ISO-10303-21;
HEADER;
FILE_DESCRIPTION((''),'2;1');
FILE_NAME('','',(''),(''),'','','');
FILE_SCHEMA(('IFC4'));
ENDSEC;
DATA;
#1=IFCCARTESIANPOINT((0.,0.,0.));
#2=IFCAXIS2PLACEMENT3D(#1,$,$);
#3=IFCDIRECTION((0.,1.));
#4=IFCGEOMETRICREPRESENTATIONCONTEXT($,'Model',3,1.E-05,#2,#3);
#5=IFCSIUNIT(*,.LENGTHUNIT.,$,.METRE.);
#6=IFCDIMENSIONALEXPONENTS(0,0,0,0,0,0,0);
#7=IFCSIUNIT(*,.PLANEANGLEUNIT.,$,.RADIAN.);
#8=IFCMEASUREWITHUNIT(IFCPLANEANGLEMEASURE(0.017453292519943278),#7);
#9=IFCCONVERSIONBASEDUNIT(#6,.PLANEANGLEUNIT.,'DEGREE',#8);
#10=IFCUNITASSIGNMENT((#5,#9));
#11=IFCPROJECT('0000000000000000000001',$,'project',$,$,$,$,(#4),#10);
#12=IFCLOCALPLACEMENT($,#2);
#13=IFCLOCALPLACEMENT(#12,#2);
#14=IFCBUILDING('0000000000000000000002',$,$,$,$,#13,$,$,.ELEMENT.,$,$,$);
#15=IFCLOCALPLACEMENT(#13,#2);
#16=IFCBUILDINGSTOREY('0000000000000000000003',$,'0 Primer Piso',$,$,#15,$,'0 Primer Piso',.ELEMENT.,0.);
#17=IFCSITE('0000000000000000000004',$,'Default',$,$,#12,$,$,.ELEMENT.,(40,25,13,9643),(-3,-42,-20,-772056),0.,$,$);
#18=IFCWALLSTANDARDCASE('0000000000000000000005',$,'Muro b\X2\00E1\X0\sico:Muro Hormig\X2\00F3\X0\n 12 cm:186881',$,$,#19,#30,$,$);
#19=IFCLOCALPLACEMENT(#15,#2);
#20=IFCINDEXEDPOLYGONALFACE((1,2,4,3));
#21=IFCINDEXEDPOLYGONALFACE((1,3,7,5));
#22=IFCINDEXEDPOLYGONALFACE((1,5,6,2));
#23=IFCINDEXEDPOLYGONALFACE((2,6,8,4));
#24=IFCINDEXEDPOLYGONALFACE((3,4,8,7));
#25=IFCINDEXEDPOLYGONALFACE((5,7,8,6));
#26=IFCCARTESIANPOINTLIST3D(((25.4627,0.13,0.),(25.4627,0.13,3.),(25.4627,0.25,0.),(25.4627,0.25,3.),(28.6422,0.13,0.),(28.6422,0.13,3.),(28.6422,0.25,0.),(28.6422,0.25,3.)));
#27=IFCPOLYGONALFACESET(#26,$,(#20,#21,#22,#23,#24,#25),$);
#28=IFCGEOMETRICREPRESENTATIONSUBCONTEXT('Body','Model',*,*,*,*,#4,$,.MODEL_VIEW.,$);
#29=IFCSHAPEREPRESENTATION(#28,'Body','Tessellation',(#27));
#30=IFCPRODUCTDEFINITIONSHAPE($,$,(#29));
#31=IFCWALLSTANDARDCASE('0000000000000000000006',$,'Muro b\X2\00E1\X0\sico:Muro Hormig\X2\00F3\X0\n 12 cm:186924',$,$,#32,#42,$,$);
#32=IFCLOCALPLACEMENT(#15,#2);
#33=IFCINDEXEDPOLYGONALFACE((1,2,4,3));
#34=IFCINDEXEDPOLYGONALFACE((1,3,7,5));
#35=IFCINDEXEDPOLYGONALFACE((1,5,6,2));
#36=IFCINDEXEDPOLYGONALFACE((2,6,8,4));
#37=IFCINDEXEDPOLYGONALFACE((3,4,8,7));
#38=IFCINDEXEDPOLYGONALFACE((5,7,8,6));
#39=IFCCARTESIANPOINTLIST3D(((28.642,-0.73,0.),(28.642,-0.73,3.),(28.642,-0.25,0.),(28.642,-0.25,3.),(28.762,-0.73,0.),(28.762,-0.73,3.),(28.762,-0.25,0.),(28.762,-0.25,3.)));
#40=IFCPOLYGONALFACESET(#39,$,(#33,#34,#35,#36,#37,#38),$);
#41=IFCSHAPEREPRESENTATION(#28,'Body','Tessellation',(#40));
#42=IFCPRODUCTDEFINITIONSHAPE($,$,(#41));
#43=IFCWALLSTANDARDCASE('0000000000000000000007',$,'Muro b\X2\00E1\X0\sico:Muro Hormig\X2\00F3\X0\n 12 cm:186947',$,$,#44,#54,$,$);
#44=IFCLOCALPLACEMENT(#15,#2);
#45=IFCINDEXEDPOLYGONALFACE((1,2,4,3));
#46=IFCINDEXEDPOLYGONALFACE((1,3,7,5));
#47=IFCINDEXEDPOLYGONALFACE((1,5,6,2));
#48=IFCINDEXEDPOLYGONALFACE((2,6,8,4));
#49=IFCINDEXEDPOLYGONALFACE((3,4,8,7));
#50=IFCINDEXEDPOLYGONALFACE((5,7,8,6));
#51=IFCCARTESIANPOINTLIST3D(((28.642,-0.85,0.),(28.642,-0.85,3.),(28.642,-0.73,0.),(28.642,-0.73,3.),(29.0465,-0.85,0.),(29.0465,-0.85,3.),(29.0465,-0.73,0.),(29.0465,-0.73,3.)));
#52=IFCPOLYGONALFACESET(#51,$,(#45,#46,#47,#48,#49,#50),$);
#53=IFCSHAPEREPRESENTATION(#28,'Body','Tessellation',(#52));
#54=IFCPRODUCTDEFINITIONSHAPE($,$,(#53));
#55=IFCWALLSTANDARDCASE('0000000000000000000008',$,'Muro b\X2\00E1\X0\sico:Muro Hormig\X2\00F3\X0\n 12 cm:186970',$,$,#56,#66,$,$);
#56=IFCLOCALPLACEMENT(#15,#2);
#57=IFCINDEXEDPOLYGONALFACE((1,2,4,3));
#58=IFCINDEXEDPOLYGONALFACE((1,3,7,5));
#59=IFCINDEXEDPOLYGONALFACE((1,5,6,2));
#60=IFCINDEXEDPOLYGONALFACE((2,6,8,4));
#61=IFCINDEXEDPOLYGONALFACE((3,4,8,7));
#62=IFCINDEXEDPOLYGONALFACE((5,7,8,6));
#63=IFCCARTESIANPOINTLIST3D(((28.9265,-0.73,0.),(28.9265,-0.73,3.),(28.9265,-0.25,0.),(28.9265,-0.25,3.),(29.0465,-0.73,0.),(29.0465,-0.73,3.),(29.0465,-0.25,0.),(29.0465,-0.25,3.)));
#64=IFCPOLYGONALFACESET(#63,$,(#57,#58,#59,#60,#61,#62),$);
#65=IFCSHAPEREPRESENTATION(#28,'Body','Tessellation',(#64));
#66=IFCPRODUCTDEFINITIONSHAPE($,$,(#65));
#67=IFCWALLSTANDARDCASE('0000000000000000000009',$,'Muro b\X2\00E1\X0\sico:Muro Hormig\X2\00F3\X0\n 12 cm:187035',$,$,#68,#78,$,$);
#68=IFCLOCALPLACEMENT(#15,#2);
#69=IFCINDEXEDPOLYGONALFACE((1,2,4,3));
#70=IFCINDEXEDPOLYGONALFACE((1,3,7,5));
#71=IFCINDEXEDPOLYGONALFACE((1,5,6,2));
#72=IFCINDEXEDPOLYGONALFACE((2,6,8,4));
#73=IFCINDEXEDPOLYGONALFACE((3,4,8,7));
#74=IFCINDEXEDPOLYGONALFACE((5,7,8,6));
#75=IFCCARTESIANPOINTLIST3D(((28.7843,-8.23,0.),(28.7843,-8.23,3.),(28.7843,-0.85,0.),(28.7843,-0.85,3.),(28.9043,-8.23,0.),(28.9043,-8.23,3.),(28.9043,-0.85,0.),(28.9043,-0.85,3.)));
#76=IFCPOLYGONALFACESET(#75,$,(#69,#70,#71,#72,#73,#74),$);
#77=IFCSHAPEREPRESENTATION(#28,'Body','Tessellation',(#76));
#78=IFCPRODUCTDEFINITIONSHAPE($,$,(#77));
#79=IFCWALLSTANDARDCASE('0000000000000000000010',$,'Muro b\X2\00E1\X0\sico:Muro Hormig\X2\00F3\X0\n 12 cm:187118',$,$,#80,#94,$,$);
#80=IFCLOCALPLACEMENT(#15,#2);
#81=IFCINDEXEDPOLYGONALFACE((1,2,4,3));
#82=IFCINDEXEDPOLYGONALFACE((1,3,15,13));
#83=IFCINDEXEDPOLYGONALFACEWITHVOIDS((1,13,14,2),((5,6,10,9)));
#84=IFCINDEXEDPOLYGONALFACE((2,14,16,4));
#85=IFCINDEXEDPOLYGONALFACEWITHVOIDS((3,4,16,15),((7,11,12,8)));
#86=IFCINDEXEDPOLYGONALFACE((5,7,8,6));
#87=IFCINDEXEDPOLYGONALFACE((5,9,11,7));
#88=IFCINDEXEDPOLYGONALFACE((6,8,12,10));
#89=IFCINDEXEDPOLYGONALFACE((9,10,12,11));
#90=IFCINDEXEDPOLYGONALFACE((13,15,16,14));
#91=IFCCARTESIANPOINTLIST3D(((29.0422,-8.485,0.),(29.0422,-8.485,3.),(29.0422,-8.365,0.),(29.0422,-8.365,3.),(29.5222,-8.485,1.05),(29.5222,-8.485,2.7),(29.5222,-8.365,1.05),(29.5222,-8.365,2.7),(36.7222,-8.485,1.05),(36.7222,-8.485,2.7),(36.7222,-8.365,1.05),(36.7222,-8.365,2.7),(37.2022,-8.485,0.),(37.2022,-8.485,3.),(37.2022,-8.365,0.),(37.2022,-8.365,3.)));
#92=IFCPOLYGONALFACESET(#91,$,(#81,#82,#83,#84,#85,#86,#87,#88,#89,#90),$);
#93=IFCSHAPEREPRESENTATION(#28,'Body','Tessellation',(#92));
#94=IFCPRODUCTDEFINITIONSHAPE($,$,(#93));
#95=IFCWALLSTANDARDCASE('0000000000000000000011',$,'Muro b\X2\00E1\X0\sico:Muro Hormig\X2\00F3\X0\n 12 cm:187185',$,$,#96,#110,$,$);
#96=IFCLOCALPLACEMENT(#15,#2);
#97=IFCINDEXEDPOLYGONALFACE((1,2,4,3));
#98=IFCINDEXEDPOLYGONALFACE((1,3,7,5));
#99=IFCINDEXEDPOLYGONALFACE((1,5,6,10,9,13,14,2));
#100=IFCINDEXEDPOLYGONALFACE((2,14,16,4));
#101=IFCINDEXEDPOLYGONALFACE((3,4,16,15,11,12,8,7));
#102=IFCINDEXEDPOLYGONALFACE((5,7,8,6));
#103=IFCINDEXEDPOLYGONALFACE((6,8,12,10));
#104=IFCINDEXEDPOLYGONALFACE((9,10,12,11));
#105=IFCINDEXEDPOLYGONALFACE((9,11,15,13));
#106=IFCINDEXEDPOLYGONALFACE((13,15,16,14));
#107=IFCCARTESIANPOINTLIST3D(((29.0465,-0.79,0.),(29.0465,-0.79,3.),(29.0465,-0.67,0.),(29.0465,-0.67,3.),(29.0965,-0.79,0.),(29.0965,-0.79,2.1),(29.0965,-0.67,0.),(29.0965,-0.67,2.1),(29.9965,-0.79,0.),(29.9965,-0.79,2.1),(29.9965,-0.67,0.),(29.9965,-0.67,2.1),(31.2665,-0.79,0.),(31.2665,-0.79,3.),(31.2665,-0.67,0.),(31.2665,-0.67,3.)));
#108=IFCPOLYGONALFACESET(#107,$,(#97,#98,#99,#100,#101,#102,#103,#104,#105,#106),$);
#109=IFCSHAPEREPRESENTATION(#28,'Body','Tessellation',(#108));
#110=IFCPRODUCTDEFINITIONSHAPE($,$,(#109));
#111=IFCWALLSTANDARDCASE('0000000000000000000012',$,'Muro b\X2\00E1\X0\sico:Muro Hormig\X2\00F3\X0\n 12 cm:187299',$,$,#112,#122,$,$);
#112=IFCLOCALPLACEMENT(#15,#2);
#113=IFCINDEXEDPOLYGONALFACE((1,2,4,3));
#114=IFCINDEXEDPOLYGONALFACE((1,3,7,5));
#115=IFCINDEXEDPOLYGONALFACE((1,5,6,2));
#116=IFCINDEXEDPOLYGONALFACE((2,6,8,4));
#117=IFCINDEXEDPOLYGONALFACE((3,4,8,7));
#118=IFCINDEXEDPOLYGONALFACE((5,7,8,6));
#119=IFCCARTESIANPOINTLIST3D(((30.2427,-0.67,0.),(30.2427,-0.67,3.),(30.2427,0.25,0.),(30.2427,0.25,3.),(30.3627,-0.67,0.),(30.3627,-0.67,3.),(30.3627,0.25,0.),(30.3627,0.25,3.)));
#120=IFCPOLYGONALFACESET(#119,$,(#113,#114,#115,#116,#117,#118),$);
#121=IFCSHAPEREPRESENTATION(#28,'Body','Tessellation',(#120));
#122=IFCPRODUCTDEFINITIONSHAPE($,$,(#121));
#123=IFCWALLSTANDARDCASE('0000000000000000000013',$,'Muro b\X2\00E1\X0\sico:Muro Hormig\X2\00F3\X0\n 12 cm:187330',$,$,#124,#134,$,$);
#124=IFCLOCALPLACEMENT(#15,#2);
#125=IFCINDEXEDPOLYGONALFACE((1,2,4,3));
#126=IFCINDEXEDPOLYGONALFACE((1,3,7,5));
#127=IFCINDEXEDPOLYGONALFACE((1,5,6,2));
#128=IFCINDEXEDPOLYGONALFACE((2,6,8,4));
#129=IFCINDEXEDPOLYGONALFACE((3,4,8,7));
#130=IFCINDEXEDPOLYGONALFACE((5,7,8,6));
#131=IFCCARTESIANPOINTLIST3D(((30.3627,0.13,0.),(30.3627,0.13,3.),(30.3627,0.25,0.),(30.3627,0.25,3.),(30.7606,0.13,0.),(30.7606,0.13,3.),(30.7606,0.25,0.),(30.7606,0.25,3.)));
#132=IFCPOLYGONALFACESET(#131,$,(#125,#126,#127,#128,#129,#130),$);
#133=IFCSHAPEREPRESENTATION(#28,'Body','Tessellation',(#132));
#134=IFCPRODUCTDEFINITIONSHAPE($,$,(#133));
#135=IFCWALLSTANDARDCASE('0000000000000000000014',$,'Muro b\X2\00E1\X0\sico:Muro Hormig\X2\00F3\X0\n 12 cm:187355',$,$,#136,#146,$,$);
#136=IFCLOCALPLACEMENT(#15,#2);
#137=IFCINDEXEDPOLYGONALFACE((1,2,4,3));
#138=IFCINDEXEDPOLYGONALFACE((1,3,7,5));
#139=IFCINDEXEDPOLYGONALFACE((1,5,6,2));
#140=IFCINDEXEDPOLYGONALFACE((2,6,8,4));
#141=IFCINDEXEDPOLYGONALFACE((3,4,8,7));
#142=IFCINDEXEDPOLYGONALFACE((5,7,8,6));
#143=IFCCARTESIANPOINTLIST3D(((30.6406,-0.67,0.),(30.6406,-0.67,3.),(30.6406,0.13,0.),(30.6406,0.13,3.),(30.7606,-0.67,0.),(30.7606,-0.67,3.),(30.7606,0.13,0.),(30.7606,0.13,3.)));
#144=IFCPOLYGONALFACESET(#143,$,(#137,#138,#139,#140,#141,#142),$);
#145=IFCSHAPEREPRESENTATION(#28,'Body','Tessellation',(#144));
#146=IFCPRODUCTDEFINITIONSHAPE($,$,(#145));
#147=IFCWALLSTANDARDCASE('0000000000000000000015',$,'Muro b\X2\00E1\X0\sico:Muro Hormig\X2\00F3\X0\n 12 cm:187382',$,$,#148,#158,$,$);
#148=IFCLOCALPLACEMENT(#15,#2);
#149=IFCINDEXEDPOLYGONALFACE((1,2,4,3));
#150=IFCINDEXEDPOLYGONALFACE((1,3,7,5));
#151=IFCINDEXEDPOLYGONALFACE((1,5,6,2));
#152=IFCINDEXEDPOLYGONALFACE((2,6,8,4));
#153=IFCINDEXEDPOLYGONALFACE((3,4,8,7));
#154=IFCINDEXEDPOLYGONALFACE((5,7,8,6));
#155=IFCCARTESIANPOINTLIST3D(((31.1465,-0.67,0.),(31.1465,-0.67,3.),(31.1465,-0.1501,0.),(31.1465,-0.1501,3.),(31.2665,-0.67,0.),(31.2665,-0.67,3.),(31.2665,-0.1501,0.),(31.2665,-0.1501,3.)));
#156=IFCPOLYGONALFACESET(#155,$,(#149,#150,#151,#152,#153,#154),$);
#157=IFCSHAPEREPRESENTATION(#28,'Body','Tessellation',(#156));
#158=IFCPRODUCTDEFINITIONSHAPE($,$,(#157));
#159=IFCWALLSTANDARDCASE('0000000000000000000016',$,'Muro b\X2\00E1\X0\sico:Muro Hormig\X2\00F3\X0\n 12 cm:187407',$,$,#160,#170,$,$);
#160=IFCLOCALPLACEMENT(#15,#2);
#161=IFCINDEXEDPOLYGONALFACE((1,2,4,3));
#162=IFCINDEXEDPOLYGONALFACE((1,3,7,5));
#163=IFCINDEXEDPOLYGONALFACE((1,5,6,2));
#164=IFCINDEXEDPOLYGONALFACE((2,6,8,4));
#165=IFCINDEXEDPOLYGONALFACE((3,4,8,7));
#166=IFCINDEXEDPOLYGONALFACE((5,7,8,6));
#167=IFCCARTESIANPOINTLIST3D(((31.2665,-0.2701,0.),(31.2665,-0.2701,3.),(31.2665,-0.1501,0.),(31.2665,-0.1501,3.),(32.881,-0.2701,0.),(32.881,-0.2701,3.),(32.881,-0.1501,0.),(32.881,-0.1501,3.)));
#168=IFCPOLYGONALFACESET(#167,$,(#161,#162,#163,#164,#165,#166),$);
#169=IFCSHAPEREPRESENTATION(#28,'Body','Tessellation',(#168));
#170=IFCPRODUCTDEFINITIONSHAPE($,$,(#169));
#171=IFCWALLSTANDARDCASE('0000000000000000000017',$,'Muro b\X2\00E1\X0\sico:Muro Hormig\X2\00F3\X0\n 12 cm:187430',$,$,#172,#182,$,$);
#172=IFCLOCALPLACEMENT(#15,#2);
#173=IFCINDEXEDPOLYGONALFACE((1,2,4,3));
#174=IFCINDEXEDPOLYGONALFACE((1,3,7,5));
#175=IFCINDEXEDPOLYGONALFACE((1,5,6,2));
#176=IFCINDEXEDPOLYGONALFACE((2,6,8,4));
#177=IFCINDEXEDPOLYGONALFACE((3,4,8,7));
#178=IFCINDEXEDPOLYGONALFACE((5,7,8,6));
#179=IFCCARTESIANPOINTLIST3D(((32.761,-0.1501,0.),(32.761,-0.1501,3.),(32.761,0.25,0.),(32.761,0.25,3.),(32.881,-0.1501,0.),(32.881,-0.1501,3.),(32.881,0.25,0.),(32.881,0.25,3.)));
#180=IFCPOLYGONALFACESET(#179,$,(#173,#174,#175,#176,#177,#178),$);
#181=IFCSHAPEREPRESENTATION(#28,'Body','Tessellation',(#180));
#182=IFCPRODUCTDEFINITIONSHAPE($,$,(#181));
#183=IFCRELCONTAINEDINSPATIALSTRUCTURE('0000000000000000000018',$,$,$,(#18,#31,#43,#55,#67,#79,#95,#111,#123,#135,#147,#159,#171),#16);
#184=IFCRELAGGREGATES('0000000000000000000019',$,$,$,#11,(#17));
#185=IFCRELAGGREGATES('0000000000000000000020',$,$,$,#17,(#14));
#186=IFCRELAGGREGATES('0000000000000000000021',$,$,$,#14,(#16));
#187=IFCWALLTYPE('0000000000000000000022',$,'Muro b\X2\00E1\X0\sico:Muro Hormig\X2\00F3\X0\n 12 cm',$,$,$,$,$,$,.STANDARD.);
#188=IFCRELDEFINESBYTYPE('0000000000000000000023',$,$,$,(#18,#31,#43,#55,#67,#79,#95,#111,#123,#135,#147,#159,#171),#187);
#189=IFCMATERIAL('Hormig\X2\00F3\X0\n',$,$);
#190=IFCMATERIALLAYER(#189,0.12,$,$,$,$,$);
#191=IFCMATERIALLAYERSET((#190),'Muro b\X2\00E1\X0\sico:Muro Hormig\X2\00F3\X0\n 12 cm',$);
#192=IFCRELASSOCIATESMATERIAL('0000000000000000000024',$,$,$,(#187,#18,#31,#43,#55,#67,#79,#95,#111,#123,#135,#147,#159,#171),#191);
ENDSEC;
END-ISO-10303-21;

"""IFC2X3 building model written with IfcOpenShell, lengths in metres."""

from ifc_helpers import new_model, entity, si_unit, converted_unit, direction, frame, frame_2d, origin, place, context, subcontext, project, spatial, rectangle, extrude, material, layer, layer_set, layer_usage, type_object, element, save


model = new_model("IFC2X3")

# Units and contexts
model_context = context("Model", 3, precision=1e-05, world=origin(), true_north=direction((0.0, 1.0)))
body_context = subcontext(model_context, "Body", "Model", "MODEL_VIEW")
ifc_project = project(units=[si_unit("LENGTHUNIT", "METRE"), converted_unit("PLANEANGLEUNIT", "DEGREE", entity("IfcPlaneAngleMeasure", 0.017453292519943278), si_unit("PLANEANGLEUNIT", "RADIAN"), dimensions=[0, 0, 0, 0, 0, 0, 0])], contexts=[model_context])

# Site, building, storey
site_placement = place(None, origin())
site = spatial("IfcSite", under=ifc_project, at=site_placement, Name="Default", CompositionType="ELEMENT", RefLatitude=(40, 25, 13, 9643), RefLongitude=(-3, -42, -20, -772056), RefElevation=0.0)
building_placement = place(site_placement, origin())
building = spatial("IfcBuilding", under=site, at=building_placement, CompositionType="ELEMENT")
storey_placement = place(building_placement, origin())
storey = spatial("IfcBuildingStorey", under=building, at=storey_placement, Name="0 Primer Piso", LongName="0 Primer Piso", CompositionType="ELEMENT", Elevation=0.0)

# Walls
ifc_material = material(Name="Hormigón")
ifc_layer = layer(ifc_material, 0.12)
ifc_layer_set = layer_set([ifc_layer], Name="Muro básico:Muro Hormigón 12 cm")
ifc_layer_usage_1 = layer_usage(ifc_layer_set, "AXIS2", "NEGATIVE", 0.06)
wall_type = type_object("IfcWallType", Name="Muro básico:Muro Hormigón 12 cm", PredefinedType="STANDARD", material=ifc_layer_set)
wall_1_placement = place(storey_placement, frame((25.4627, 0.19, 0.0)))
element("IfcWallStandardCase", 1, at=wall_1_placement, inside=storey, type_object=wall_type, material=ifc_layer_usage_1, Name="Muro básico:Muro Hormigón 12 cm:186881", context=body_context, shape_type="SweptSolid", body=[
    extrude(rectangle(XDim=3.1795, YDim=0.12, at=frame_2d((1.5897, 0.0), x_axis=(-1.0, 0.0))), origin(), (0.0, 0.0, 1.0), 3.0),
])
ifc_layer_usage_2 = layer_usage(ifc_layer_set, "AXIS2", "NEGATIVE", 0.06)
wall_2_placement = place(storey_placement, frame((28.702, -0.25, 0.0), z_axis=(0.0, 0.0, 1.0), x_axis=(0.0, -1.0, 0.0)))
element("IfcWallStandardCase", 2, at=wall_2_placement, inside=storey, type_object=wall_type, material=ifc_layer_usage_2, Name="Muro básico:Muro Hormigón 12 cm:186924", context=body_context, shape_type="SweptSolid", body=[
    extrude(rectangle(XDim=0.48, YDim=0.12, at=frame_2d((0.24, 0.0), x_axis=(-1.0, 0.0))), origin(), (0.0, 0.0, 1.0), 3.0),
])
ifc_layer_usage_3 = layer_usage(ifc_layer_set, "AXIS2", "NEGATIVE", 0.06)
wall_3_placement = place(storey_placement, frame((28.642, -0.79, 0.0)))
element("IfcWallStandardCase", 3, at=wall_3_placement, inside=storey, type_object=wall_type, material=ifc_layer_usage_3, Name="Muro básico:Muro Hormigón 12 cm:186947", context=body_context, shape_type="SweptSolid", body=[
    extrude(rectangle(XDim=0.4045, YDim=0.12, at=frame_2d((0.2023, 0.0), x_axis=(-1.0, 0.0))), origin(), (0.0, 0.0, 1.0), 3.0),
])
ifc_layer_usage_4 = layer_usage(ifc_layer_set, "AXIS2", "NEGATIVE", 0.06)
wall_4_placement = place(storey_placement, frame((28.9865, -0.73, 0.0), z_axis=(0.0, 0.0, 1.0), x_axis=(0.0, 1.0, 0.0)))
element("IfcWallStandardCase", 4, at=wall_4_placement, inside=storey, type_object=wall_type, material=ifc_layer_usage_4, Name="Muro básico:Muro Hormigón 12 cm:186970", context=body_context, shape_type="SweptSolid", body=[
    extrude(rectangle(XDim=0.48, YDim=0.12, at=frame_2d((0.24, 0.0), x_axis=(-1.0, 0.0))), origin(), (0.0, 0.0, 1.0), 3.0),
])
ifc_layer_usage_5 = layer_usage(ifc_layer_set, "AXIS2", "NEGATIVE", 0.06)
wall_5_placement = place(storey_placement, frame((28.8443, -0.85, 0.0), z_axis=(0.0, 0.0, 1.0), x_axis=(0.0, -1.0, 0.0)))
element("IfcWallStandardCase", 5, at=wall_5_placement, inside=storey, type_object=wall_type, material=ifc_layer_usage_5, Name="Muro básico:Muro Hormigón 12 cm:187035", context=body_context, shape_type="SweptSolid", body=[
    extrude(rectangle(XDim=7.38, YDim=0.12, at=frame_2d((3.69, 0.0), x_axis=(-1.0, 0.0))), origin(), (0.0, 0.0, 1.0), 3.0),
])

# Walls, openings
ifc_layer_usage_6 = layer_usage(ifc_layer_set, "AXIS2", "NEGATIVE", 0.06)
wall_6_placement = place(storey_placement, frame((29.0422, -8.425, 0.0)))
wall_6 = element("IfcWallStandardCase", 6, at=wall_6_placement, inside=storey, type_object=wall_type, material=ifc_layer_usage_6, Name="Muro básico:Muro Hormigón 12 cm:187118", context=body_context, shape_type="SweptSolid", body=[
    extrude(rectangle(XDim=8.16, YDim=0.12, at=frame_2d((4.08, 0.0), x_axis=(-1.0, 0.0))), origin(), (0.0, 0.0, 1.0), 3.0),
])
opening_1_placement = place(wall_6_placement, frame((0.48, -0.06, 1.05)))
element("IfcOpeningElement", 7, at=opening_1_placement, cuts=wall_6, ObjectType="Opening", context=body_context, shape_type="SweptSolid", body=[
    extrude(rectangle(XDim=1.65, YDim=7.2, at=frame_2d((0.825, 3.6), x_axis=(1.0, 0.0))), frame((0.0, 0.0, 0.0), z_axis=(0.0, 1.0, 0.0), x_axis=(0.0, 0.0, 1.0)), (0.0, 0.0, 1.0), 0.12),
])
ifc_layer_usage_7 = layer_usage(ifc_layer_set, "AXIS2", "NEGATIVE", 0.06)
wall_7_placement = place(storey_placement, frame((29.0465, -0.73, 0.0)))
wall_7 = element("IfcWallStandardCase", 8, at=wall_7_placement, inside=storey, type_object=wall_type, material=ifc_layer_usage_7, Name="Muro básico:Muro Hormigón 12 cm:187185", context=body_context, shape_type="SweptSolid", body=[
    extrude(rectangle(XDim=2.22, YDim=0.12, at=frame_2d((1.11, 0.0), x_axis=(-1.0, 0.0))), origin(), (0.0, 0.0, 1.0), 3.0),
])
opening_2_placement = place(wall_7_placement, frame((0.05, -0.06, 0.0)))
element("IfcOpeningElement", 9, at=opening_2_placement, cuts=wall_7, ObjectType="Opening", context=body_context, shape_type="SweptSolid", body=[
    extrude(rectangle(XDim=2.1, YDim=0.9, at=frame_2d((1.05, 0.45), x_axis=(1.0, 0.0))), frame((0.0, 0.0, 0.0), z_axis=(0.0, 1.0, 0.0), x_axis=(0.0, 0.0, 1.0)), (0.0, 0.0, 1.0), 0.12),
])

# Walls
ifc_layer_usage_8 = layer_usage(ifc_layer_set, "AXIS2", "NEGATIVE", 0.06)
wall_8_placement = place(storey_placement, frame((30.3027, -0.67, 0.0), z_axis=(0.0, 0.0, 1.0), x_axis=(0.0, 1.0, 0.0)))
element("IfcWallStandardCase", 10, at=wall_8_placement, inside=storey, type_object=wall_type, material=ifc_layer_usage_8, Name="Muro básico:Muro Hormigón 12 cm:187299", context=body_context, shape_type="SweptSolid", body=[
    extrude(rectangle(XDim=0.92, YDim=0.12, at=frame_2d((0.46, 0.0), x_axis=(-1.0, 0.0))), origin(), (0.0, 0.0, 1.0), 3.0),
])
ifc_layer_usage_9 = layer_usage(ifc_layer_set, "AXIS2", "NEGATIVE", 0.06)
wall_9_placement = place(storey_placement, frame((30.3627, 0.19, 0.0)))
element("IfcWallStandardCase", 11, at=wall_9_placement, inside=storey, type_object=wall_type, material=ifc_layer_usage_9, Name="Muro básico:Muro Hormigón 12 cm:187330", context=body_context, shape_type="SweptSolid", body=[
    extrude(rectangle(XDim=0.3979, YDim=0.12, at=frame_2d((0.199, 0.0), x_axis=(-1.0, 0.0))), origin(), (0.0, 0.0, 1.0), 3.0),
])
ifc_layer_usage_10 = layer_usage(ifc_layer_set, "AXIS2", "NEGATIVE", 0.06)
wall_10_placement = place(storey_placement, frame((30.7006, 0.13, 0.0), z_axis=(0.0, 0.0, 1.0), x_axis=(0.0, -1.0, 0.0)))
element("IfcWallStandardCase", 12, at=wall_10_placement, inside=storey, type_object=wall_type, material=ifc_layer_usage_10, Name="Muro básico:Muro Hormigón 12 cm:187355", context=body_context, shape_type="SweptSolid", body=[
    extrude(rectangle(XDim=0.8, YDim=0.12, at=frame_2d((0.4, 0.0), x_axis=(-1.0, 0.0))), origin(), (0.0, 0.0, 1.0), 3.0),
])
ifc_layer_usage_11 = layer_usage(ifc_layer_set, "AXIS2", "NEGATIVE", 0.06)
wall_11_placement = place(storey_placement, frame((31.2065, -0.67, 0.0), z_axis=(0.0, 0.0, 1.0), x_axis=(0.0, 1.0, 0.0)))
element("IfcWallStandardCase", 13, at=wall_11_placement, inside=storey, type_object=wall_type, material=ifc_layer_usage_11, Name="Muro básico:Muro Hormigón 12 cm:187382", context=body_context, shape_type="SweptSolid", body=[
    extrude(rectangle(XDim=0.5199, YDim=0.12, at=frame_2d((0.26, 0.0), x_axis=(-1.0, 0.0))), origin(), (0.0, 0.0, 1.0), 3.0),
])
ifc_layer_usage_12 = layer_usage(ifc_layer_set, "AXIS2", "NEGATIVE", 0.06)
wall_12_placement = place(storey_placement, frame((31.2665, -0.2101, 0.0)))
element("IfcWallStandardCase", 14, at=wall_12_placement, inside=storey, type_object=wall_type, material=ifc_layer_usage_12, Name="Muro básico:Muro Hormigón 12 cm:187407", context=body_context, shape_type="SweptSolid", body=[
    extrude(rectangle(XDim=1.6145, YDim=0.12, at=frame_2d((0.8072, 0.0), x_axis=(-1.0, 0.0))), origin(), (0.0, 0.0, 1.0), 3.0),
])
ifc_layer_usage_13 = layer_usage(ifc_layer_set, "AXIS2", "NEGATIVE", 0.06)
wall_13_placement = place(storey_placement, frame((32.821, -0.1501, 0.0), z_axis=(0.0, 0.0, 1.0), x_axis=(0.0, 1.0, 0.0)))
element("IfcWallStandardCase", 15, at=wall_13_placement, inside=storey, type_object=wall_type, material=ifc_layer_usage_13, Name="Muro básico:Muro Hormigón 12 cm:187430", context=body_context, shape_type="SweptSolid", body=[
    extrude(rectangle(XDim=0.4001, YDim=0.12, at=frame_2d((0.2, 0.0), x_axis=(-1.0, 0.0))), origin(), (0.0, 0.0, 1.0), 3.0),
])

save(model, "model.ifc")
